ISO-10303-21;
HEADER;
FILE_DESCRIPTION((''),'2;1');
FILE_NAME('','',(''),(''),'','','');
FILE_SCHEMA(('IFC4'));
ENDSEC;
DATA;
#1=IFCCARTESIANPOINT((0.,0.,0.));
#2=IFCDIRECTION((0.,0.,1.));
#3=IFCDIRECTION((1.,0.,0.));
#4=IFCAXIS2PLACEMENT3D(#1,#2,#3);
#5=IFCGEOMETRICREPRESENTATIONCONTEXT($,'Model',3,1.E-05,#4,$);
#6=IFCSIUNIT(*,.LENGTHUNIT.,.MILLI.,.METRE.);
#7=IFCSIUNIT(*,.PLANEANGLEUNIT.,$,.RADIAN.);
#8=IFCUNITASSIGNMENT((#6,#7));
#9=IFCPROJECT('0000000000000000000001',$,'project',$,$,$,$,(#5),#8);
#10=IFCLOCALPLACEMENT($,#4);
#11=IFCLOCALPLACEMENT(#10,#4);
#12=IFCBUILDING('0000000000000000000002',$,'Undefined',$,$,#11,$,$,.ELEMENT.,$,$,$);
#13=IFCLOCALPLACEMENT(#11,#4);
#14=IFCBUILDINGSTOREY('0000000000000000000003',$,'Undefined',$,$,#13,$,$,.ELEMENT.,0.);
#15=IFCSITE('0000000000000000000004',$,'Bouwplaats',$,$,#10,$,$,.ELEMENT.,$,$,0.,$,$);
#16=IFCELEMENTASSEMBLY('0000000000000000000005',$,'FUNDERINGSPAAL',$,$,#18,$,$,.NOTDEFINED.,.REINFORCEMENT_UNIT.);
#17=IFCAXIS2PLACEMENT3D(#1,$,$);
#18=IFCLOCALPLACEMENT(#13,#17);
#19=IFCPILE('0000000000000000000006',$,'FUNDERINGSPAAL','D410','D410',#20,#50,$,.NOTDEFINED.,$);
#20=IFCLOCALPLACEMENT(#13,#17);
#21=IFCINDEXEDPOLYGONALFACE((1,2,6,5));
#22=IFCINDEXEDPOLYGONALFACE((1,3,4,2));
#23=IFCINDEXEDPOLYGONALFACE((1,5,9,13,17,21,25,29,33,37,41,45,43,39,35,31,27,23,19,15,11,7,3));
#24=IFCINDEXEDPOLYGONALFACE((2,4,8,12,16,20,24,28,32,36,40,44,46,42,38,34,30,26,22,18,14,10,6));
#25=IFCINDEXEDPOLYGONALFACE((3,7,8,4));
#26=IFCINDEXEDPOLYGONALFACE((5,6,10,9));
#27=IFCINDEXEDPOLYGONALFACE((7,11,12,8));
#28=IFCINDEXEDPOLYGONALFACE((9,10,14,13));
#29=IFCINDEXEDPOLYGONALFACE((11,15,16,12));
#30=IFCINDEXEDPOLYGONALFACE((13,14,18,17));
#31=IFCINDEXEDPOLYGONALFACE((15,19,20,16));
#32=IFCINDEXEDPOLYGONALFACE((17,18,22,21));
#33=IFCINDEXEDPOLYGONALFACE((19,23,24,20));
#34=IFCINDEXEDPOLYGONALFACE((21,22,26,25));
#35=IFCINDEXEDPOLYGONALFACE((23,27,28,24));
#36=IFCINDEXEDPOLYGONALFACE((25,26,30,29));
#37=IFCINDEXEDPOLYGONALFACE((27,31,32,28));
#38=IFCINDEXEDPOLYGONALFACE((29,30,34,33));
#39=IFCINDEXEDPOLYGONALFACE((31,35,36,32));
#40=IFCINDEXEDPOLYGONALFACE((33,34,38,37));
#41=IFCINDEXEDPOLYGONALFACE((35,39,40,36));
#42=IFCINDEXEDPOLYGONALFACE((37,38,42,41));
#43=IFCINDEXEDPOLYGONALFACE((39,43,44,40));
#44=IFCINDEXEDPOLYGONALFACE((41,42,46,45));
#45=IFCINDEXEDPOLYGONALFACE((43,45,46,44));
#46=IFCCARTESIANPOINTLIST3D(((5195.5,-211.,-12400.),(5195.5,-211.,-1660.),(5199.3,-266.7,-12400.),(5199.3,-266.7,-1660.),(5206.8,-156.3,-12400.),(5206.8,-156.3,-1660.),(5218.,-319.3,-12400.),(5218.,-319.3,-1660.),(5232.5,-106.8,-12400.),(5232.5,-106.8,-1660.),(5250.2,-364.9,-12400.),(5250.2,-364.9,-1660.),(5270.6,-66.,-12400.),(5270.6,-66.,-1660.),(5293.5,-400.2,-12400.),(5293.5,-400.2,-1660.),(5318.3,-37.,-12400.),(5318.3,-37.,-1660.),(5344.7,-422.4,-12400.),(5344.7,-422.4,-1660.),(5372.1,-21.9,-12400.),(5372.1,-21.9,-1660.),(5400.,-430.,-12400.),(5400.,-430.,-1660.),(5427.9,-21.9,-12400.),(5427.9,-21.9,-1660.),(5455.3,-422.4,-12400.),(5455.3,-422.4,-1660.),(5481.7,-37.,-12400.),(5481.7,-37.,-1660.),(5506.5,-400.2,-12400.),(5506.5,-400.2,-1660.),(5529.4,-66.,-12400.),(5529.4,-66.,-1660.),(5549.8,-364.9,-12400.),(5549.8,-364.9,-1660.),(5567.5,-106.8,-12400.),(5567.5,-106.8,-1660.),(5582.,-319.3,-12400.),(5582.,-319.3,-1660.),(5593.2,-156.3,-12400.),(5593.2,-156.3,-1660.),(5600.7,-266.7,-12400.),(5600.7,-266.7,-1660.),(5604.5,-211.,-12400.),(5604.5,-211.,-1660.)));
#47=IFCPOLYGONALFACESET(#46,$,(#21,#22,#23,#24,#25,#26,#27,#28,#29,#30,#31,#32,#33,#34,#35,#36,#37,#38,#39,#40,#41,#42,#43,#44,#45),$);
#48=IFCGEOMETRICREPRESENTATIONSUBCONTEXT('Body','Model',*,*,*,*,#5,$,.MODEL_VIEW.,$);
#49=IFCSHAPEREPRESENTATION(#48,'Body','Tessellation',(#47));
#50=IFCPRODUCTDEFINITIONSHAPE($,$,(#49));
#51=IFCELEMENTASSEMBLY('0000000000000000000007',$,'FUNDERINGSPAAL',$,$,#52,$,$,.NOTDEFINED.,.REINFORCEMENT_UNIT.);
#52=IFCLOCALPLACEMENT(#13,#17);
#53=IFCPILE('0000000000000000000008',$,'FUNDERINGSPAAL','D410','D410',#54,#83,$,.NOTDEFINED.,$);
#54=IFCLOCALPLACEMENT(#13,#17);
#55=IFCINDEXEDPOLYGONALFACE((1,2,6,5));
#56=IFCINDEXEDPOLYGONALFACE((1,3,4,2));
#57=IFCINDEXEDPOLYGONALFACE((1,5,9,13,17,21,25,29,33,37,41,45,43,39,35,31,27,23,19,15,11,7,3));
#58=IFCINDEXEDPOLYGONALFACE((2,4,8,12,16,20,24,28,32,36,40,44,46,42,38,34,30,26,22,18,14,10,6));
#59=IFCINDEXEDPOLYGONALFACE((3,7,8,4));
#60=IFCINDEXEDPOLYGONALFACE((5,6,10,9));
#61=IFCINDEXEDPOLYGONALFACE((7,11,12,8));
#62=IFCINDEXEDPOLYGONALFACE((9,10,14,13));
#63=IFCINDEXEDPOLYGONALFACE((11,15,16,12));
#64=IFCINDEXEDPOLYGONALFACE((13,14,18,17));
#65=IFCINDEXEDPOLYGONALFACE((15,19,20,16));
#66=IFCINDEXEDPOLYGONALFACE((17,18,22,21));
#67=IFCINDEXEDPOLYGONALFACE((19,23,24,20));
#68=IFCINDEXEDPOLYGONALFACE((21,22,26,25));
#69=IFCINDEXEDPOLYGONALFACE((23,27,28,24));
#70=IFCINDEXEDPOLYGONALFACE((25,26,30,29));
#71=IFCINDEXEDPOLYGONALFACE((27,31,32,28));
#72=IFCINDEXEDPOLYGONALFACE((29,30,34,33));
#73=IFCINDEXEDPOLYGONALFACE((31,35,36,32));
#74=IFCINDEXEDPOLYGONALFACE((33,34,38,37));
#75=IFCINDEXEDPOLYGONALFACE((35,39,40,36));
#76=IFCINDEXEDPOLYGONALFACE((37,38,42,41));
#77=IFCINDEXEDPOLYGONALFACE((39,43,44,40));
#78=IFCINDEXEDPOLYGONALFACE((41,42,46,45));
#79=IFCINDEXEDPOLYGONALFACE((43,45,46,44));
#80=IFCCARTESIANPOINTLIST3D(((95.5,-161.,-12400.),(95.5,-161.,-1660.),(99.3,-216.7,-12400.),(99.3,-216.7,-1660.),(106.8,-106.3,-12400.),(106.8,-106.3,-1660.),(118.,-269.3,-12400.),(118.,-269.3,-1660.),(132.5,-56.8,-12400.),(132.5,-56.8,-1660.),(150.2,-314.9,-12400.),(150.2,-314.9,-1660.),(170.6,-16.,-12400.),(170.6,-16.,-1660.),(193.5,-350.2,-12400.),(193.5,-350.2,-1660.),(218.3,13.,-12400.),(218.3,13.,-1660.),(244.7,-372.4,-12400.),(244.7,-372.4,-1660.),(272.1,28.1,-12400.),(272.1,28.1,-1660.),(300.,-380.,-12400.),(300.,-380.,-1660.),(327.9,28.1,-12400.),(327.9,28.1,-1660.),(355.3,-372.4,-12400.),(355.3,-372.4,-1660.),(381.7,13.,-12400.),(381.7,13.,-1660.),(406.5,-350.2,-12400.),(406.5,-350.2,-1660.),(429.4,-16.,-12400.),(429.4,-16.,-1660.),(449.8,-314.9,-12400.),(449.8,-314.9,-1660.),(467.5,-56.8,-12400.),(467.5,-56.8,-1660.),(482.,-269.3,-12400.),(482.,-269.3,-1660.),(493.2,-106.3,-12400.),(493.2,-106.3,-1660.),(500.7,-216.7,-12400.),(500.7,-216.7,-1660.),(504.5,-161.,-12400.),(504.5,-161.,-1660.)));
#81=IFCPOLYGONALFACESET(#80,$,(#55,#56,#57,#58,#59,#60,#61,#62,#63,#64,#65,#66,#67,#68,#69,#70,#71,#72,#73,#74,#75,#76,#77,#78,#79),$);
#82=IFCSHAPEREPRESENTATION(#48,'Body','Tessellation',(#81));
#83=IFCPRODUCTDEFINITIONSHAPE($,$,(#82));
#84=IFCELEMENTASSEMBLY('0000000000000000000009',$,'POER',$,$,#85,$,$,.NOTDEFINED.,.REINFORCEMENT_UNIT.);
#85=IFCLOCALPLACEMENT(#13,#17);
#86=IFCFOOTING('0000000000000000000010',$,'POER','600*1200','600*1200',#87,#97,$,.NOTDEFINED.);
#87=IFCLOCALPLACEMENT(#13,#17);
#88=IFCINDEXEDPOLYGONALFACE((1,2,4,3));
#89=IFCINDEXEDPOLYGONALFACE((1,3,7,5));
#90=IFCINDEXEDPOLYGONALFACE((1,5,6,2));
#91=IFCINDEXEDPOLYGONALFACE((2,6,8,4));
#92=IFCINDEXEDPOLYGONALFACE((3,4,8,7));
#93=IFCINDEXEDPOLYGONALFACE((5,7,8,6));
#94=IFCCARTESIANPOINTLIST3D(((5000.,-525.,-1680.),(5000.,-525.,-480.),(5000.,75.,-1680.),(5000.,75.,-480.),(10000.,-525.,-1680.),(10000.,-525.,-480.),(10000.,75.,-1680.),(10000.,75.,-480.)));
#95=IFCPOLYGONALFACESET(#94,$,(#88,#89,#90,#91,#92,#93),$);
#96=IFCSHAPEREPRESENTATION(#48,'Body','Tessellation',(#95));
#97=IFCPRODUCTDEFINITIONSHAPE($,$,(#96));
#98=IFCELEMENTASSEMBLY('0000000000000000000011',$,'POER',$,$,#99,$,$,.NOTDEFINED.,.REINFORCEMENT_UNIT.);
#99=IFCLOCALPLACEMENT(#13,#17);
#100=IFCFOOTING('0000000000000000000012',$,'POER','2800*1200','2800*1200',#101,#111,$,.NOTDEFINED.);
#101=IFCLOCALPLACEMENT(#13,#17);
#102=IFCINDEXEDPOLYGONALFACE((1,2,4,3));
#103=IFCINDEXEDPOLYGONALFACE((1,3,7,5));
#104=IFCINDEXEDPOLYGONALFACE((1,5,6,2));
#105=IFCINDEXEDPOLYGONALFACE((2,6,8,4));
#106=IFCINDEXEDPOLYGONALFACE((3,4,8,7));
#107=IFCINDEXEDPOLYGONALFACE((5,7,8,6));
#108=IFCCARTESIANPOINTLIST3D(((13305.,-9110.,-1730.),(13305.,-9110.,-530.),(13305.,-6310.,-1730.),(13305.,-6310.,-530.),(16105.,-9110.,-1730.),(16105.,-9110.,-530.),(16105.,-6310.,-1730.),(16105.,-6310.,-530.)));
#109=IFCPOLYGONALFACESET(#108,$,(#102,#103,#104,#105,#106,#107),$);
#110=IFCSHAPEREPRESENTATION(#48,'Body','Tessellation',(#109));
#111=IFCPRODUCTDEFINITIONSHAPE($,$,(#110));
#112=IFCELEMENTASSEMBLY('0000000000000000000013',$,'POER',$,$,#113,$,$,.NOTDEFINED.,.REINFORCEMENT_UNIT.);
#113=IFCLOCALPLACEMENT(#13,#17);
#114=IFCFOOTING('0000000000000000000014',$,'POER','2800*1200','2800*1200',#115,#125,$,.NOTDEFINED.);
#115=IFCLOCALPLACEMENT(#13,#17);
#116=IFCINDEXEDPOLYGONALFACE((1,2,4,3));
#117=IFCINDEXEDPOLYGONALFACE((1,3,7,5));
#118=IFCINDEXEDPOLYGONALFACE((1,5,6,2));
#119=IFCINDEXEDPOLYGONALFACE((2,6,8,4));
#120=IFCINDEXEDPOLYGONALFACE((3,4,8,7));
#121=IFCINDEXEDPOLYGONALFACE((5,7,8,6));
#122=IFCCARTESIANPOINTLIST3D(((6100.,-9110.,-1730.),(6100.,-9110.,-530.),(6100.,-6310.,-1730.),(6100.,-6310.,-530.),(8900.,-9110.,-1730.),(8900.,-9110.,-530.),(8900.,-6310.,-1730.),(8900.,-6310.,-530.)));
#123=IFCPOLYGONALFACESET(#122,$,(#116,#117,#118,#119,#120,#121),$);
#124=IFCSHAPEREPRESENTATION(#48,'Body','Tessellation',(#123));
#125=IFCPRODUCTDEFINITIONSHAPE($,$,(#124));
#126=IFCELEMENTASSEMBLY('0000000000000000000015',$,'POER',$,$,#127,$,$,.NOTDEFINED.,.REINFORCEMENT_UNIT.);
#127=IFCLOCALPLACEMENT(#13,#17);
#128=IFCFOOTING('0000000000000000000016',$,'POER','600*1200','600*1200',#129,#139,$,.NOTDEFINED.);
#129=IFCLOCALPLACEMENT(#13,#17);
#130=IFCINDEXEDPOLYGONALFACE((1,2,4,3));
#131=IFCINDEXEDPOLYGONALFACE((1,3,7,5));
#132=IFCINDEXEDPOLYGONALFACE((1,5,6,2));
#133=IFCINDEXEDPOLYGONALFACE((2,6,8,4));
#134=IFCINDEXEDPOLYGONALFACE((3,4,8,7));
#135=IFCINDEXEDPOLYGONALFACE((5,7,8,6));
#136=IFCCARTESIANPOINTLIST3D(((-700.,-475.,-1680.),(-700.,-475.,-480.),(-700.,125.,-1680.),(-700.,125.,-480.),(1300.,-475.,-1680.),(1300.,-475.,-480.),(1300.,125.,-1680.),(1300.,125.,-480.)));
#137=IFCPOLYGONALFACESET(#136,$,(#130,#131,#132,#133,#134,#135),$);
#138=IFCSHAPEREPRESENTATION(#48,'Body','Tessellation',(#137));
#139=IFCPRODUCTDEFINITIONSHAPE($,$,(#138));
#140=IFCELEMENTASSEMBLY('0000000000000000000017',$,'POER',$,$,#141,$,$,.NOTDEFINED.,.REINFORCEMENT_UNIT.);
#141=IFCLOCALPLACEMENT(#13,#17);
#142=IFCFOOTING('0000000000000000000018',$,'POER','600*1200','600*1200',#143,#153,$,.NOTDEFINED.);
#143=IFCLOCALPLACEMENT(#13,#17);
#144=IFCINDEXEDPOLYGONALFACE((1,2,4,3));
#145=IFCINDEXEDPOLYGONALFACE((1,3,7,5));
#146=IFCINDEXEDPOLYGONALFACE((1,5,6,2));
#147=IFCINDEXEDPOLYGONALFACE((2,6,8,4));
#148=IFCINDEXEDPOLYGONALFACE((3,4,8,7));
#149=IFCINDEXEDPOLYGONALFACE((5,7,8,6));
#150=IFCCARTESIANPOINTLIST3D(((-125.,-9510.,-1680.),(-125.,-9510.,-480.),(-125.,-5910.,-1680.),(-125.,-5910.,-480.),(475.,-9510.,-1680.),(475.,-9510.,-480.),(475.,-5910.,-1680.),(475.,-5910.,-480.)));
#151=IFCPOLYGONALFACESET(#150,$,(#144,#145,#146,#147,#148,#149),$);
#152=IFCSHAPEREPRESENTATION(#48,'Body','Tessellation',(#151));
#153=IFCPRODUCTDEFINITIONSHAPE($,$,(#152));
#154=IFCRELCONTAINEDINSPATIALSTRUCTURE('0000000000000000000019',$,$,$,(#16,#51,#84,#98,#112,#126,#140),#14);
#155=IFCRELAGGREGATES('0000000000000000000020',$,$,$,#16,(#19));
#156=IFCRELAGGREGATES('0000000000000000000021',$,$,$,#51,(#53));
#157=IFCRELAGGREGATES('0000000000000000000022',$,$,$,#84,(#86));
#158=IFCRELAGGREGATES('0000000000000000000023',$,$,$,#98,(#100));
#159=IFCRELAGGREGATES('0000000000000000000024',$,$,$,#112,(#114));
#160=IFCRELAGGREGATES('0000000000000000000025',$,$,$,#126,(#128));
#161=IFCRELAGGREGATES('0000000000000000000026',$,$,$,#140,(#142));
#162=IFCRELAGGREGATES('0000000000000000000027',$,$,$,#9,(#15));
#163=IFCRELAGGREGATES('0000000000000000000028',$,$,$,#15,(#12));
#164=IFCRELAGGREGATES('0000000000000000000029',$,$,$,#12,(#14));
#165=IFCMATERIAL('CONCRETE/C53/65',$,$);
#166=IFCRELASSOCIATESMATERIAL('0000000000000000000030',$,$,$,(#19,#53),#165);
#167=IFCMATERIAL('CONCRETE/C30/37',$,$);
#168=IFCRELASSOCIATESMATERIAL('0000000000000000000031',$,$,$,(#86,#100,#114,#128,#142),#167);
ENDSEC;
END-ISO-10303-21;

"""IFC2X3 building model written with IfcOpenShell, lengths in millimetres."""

from ifc_helpers import new_model, si_unit, frame, origin_with_axes, origin_2d_with_axis, place, context, subcontext, project, spatial, rectangle, circle, extrude, clip, halfspace, material, element, aggregate, save


model = new_model("IFC2X3")

# Units and contexts
model_context = context("Model", 3, precision=1e-05, world=origin_with_axes())
body_context = subcontext(model_context, "Body", "Model", "MODEL_VIEW")
ifc_project = project(units=[si_unit("LENGTHUNIT", "METRE", prefix="MILLI"), si_unit("PLANEANGLEUNIT", "RADIAN")], contexts=[model_context])

# Site, building, storey
site_placement = place(None, origin_with_axes())
site = spatial("IfcSite", under=ifc_project, at=site_placement, Name="Bouwplaats", CompositionType="ELEMENT", RefElevation=0.0)
building_placement = place(site_placement, origin_with_axes())
building = spatial("IfcBuilding", under=site, at=building_placement, Name="Undefined", CompositionType="ELEMENT")
storey_placement = place(building_placement, origin_with_axes())
storey = spatial("IfcBuildingStorey", under=building, at=storey_placement, Name="Undefined", CompositionType="ELEMENT", Elevation=0.0)

# Element assemblies, piles
ifc_material_1 = material(Name="CONCRETE/C53/65")
assembly_1_placement = place(storey_placement, origin_with_axes())
assembly_1 = element("IfcElementAssembly", 1, at=assembly_1_placement, inside=storey, Name="FUNDERINGSPAAL", AssemblyPlace="NOTDEFINED", PredefinedType="REINFORCEMENT_UNIT")
pile_1_placement = place(assembly_1_placement, frame((5400.0, -225.0, -1660.0), z_axis=(1.0, 0.0, 0.0), x_axis=(0.0, 0.0, -1.0)))
pile_1 = element("IfcPile", 2, at=pile_1_placement, material=ifc_material_1, Name="FUNDERINGSPAAL", Description="D410", ObjectType="D410", PredefinedType="NOTDEFINED", context=body_context, shape_type="Clipping", body=[
    clip(extrude(circle(Radius=205.0, at=origin_2d_with_axis()), frame((10740.0, 0.0, 0.0), z_axis=(-1.0, 0.0, 0.0), x_axis=(0.0, -1.0, 0.0)), (0.0, 0.0, 1.0), 10740.0), halfspace(frame((0.0, 205.0, -205.0), z_axis=(-1.0, 0.0, 0.0), x_axis=(0.0, 0.0, 1.0)), False)),
])
aggregate(assembly_1, [pile_1])
assembly_2_placement = place(storey_placement, origin_with_axes())
assembly_2 = element("IfcElementAssembly", 3, at=assembly_2_placement, inside=storey, Name="FUNDERINGSPAAL", AssemblyPlace="NOTDEFINED", PredefinedType="REINFORCEMENT_UNIT")
pile_2_placement = place(assembly_2_placement, frame((300.0, -175.0, -1660.0), z_axis=(1.0, 0.0, 0.0), x_axis=(0.0, 0.0, -1.0)))
pile_2 = element("IfcPile", 4, at=pile_2_placement, material=ifc_material_1, Name="FUNDERINGSPAAL", Description="D410", ObjectType="D410", PredefinedType="NOTDEFINED", context=body_context, shape_type="Clipping", body=[
    clip(extrude(circle(Radius=205.0, at=origin_2d_with_axis()), frame((10740.0, 0.0, 0.0), z_axis=(-1.0, 0.0, 0.0), x_axis=(0.0, -1.0, 0.0)), (0.0, 0.0, 1.0), 10740.0), halfspace(frame((0.0, 205.0, -205.0), z_axis=(-1.0, 0.0, 0.0), x_axis=(0.0, 0.0, 1.0)), False)),
])
aggregate(assembly_2, [pile_2])

# Element assemblies, footings
assembly_3_placement = place(storey_placement, origin_with_axes())
assembly_3 = element("IfcElementAssembly", 5, at=assembly_3_placement, inside=storey, Name="POER", AssemblyPlace="NOTDEFINED", PredefinedType="REINFORCEMENT_UNIT")
ifc_material_2 = material(Name="CONCRETE/C30/37")
footing_1_placement = place(assembly_3_placement, frame((5000.0, -225.0, -1080.0), z_axis=(0.0, 0.0, 1.0), x_axis=(1.0, 0.0, 0.0)))
footing_1 = element("IfcFooting", 6, at=footing_1_placement, material=ifc_material_2, Name="POER", Description="600*1200", ObjectType="600*1200", PredefinedType="NOTDEFINED", context=body_context, shape_type="SweptSolid", body=[
    extrude(rectangle(XDim=600.0, YDim=1200.0, at=origin_2d_with_axis()), frame((5000.0, 0.0, 0.0), z_axis=(-1.0, 0.0, 0.0), x_axis=(0.0, -1.0, 0.0)), (0.0, 0.0, 1.0), 5000.0),
])
aggregate(assembly_3, [footing_1])
assembly_4_placement = place(storey_placement, origin_with_axes())
assembly_4 = element("IfcElementAssembly", 7, at=assembly_4_placement, inside=storey, Name="POER", AssemblyPlace="NOTDEFINED", PredefinedType="REINFORCEMENT_UNIT")
footing_2_placement = place(assembly_4_placement, frame((13305.0, -7710.0, -1130.0), z_axis=(0.0, 0.0, 1.0), x_axis=(1.0, 0.0, 0.0)))
footing_2 = element("IfcFooting", 8, at=footing_2_placement, material=ifc_material_2, Name="POER", Description="2800*1200", ObjectType="2800*1200", PredefinedType="NOTDEFINED", context=body_context, shape_type="SweptSolid", body=[
    extrude(rectangle(XDim=2800.0, YDim=1200.0, at=origin_2d_with_axis()), frame((2800.0, 0.0, 0.0), z_axis=(-1.0, 0.0, 0.0), x_axis=(0.0, -1.0, 0.0)), (0.0, 0.0, 1.0), 2800.0),
])
aggregate(assembly_4, [footing_2])
assembly_5_placement = place(storey_placement, origin_with_axes())
assembly_5 = element("IfcElementAssembly", 9, at=assembly_5_placement, inside=storey, Name="POER", AssemblyPlace="NOTDEFINED", PredefinedType="REINFORCEMENT_UNIT")
footing_3_placement = place(assembly_5_placement, frame((6100.0, -7710.0, -1130.0), z_axis=(0.0, 0.0, 1.0), x_axis=(1.0, 0.0, 0.0)))
footing_3 = element("IfcFooting", 10, at=footing_3_placement, material=ifc_material_2, Name="POER", Description="2800*1200", ObjectType="2800*1200", PredefinedType="NOTDEFINED", context=body_context, shape_type="SweptSolid", body=[
    extrude(rectangle(XDim=2800.0, YDim=1200.0, at=origin_2d_with_axis()), frame((2800.0, 0.0, 0.0), z_axis=(-1.0, 0.0, 0.0), x_axis=(0.0, -1.0, 0.0)), (0.0, 0.0, 1.0), 2800.0),
])
aggregate(assembly_5, [footing_3])
assembly_6_placement = place(storey_placement, origin_with_axes())
assembly_6 = element("IfcElementAssembly", 11, at=assembly_6_placement, inside=storey, Name="POER", AssemblyPlace="NOTDEFINED", PredefinedType="REINFORCEMENT_UNIT")
footing_4_placement = place(assembly_6_placement, frame((-700.0, -175.0, -1080.0), z_axis=(0.0, 0.0, 1.0), x_axis=(1.0, 0.0, 0.0)))
footing_4 = element("IfcFooting", 12, at=footing_4_placement, material=ifc_material_2, Name="POER", Description="600*1200", ObjectType="600*1200", PredefinedType="NOTDEFINED", context=body_context, shape_type="SweptSolid", body=[
    extrude(rectangle(XDim=600.0, YDim=1200.0, at=origin_2d_with_axis()), frame((2000.0, 0.0, 0.0), z_axis=(-1.0, 0.0, 0.0), x_axis=(0.0, -1.0, 0.0)), (0.0, 0.0, 1.0), 2000.0),
])
aggregate(assembly_6, [footing_4])
assembly_7_placement = place(storey_placement, origin_with_axes())
assembly_7 = element("IfcElementAssembly", 13, at=assembly_7_placement, inside=storey, Name="POER", AssemblyPlace="NOTDEFINED", PredefinedType="REINFORCEMENT_UNIT")
footing_5_placement = place(assembly_7_placement, frame((175.0, -9510.0, -1080.0), z_axis=(0.0, 0.0, 1.0), x_axis=(0.0, 1.0, 0.0)))
footing_5 = element("IfcFooting", 14, at=footing_5_placement, material=ifc_material_2, Name="POER", Description="600*1200", ObjectType="600*1200", PredefinedType="NOTDEFINED", context=body_context, shape_type="SweptSolid", body=[
    extrude(rectangle(XDim=600.0, YDim=1200.0, at=origin_2d_with_axis()), frame((3600.0, 0.0, 0.0), z_axis=(-1.0, 0.0, 0.0), x_axis=(0.0, -1.0, 0.0)), (0.0, 0.0, 1.0), 3600.0),
])
aggregate(assembly_7, [footing_5])

save(model, "model.ifc")
